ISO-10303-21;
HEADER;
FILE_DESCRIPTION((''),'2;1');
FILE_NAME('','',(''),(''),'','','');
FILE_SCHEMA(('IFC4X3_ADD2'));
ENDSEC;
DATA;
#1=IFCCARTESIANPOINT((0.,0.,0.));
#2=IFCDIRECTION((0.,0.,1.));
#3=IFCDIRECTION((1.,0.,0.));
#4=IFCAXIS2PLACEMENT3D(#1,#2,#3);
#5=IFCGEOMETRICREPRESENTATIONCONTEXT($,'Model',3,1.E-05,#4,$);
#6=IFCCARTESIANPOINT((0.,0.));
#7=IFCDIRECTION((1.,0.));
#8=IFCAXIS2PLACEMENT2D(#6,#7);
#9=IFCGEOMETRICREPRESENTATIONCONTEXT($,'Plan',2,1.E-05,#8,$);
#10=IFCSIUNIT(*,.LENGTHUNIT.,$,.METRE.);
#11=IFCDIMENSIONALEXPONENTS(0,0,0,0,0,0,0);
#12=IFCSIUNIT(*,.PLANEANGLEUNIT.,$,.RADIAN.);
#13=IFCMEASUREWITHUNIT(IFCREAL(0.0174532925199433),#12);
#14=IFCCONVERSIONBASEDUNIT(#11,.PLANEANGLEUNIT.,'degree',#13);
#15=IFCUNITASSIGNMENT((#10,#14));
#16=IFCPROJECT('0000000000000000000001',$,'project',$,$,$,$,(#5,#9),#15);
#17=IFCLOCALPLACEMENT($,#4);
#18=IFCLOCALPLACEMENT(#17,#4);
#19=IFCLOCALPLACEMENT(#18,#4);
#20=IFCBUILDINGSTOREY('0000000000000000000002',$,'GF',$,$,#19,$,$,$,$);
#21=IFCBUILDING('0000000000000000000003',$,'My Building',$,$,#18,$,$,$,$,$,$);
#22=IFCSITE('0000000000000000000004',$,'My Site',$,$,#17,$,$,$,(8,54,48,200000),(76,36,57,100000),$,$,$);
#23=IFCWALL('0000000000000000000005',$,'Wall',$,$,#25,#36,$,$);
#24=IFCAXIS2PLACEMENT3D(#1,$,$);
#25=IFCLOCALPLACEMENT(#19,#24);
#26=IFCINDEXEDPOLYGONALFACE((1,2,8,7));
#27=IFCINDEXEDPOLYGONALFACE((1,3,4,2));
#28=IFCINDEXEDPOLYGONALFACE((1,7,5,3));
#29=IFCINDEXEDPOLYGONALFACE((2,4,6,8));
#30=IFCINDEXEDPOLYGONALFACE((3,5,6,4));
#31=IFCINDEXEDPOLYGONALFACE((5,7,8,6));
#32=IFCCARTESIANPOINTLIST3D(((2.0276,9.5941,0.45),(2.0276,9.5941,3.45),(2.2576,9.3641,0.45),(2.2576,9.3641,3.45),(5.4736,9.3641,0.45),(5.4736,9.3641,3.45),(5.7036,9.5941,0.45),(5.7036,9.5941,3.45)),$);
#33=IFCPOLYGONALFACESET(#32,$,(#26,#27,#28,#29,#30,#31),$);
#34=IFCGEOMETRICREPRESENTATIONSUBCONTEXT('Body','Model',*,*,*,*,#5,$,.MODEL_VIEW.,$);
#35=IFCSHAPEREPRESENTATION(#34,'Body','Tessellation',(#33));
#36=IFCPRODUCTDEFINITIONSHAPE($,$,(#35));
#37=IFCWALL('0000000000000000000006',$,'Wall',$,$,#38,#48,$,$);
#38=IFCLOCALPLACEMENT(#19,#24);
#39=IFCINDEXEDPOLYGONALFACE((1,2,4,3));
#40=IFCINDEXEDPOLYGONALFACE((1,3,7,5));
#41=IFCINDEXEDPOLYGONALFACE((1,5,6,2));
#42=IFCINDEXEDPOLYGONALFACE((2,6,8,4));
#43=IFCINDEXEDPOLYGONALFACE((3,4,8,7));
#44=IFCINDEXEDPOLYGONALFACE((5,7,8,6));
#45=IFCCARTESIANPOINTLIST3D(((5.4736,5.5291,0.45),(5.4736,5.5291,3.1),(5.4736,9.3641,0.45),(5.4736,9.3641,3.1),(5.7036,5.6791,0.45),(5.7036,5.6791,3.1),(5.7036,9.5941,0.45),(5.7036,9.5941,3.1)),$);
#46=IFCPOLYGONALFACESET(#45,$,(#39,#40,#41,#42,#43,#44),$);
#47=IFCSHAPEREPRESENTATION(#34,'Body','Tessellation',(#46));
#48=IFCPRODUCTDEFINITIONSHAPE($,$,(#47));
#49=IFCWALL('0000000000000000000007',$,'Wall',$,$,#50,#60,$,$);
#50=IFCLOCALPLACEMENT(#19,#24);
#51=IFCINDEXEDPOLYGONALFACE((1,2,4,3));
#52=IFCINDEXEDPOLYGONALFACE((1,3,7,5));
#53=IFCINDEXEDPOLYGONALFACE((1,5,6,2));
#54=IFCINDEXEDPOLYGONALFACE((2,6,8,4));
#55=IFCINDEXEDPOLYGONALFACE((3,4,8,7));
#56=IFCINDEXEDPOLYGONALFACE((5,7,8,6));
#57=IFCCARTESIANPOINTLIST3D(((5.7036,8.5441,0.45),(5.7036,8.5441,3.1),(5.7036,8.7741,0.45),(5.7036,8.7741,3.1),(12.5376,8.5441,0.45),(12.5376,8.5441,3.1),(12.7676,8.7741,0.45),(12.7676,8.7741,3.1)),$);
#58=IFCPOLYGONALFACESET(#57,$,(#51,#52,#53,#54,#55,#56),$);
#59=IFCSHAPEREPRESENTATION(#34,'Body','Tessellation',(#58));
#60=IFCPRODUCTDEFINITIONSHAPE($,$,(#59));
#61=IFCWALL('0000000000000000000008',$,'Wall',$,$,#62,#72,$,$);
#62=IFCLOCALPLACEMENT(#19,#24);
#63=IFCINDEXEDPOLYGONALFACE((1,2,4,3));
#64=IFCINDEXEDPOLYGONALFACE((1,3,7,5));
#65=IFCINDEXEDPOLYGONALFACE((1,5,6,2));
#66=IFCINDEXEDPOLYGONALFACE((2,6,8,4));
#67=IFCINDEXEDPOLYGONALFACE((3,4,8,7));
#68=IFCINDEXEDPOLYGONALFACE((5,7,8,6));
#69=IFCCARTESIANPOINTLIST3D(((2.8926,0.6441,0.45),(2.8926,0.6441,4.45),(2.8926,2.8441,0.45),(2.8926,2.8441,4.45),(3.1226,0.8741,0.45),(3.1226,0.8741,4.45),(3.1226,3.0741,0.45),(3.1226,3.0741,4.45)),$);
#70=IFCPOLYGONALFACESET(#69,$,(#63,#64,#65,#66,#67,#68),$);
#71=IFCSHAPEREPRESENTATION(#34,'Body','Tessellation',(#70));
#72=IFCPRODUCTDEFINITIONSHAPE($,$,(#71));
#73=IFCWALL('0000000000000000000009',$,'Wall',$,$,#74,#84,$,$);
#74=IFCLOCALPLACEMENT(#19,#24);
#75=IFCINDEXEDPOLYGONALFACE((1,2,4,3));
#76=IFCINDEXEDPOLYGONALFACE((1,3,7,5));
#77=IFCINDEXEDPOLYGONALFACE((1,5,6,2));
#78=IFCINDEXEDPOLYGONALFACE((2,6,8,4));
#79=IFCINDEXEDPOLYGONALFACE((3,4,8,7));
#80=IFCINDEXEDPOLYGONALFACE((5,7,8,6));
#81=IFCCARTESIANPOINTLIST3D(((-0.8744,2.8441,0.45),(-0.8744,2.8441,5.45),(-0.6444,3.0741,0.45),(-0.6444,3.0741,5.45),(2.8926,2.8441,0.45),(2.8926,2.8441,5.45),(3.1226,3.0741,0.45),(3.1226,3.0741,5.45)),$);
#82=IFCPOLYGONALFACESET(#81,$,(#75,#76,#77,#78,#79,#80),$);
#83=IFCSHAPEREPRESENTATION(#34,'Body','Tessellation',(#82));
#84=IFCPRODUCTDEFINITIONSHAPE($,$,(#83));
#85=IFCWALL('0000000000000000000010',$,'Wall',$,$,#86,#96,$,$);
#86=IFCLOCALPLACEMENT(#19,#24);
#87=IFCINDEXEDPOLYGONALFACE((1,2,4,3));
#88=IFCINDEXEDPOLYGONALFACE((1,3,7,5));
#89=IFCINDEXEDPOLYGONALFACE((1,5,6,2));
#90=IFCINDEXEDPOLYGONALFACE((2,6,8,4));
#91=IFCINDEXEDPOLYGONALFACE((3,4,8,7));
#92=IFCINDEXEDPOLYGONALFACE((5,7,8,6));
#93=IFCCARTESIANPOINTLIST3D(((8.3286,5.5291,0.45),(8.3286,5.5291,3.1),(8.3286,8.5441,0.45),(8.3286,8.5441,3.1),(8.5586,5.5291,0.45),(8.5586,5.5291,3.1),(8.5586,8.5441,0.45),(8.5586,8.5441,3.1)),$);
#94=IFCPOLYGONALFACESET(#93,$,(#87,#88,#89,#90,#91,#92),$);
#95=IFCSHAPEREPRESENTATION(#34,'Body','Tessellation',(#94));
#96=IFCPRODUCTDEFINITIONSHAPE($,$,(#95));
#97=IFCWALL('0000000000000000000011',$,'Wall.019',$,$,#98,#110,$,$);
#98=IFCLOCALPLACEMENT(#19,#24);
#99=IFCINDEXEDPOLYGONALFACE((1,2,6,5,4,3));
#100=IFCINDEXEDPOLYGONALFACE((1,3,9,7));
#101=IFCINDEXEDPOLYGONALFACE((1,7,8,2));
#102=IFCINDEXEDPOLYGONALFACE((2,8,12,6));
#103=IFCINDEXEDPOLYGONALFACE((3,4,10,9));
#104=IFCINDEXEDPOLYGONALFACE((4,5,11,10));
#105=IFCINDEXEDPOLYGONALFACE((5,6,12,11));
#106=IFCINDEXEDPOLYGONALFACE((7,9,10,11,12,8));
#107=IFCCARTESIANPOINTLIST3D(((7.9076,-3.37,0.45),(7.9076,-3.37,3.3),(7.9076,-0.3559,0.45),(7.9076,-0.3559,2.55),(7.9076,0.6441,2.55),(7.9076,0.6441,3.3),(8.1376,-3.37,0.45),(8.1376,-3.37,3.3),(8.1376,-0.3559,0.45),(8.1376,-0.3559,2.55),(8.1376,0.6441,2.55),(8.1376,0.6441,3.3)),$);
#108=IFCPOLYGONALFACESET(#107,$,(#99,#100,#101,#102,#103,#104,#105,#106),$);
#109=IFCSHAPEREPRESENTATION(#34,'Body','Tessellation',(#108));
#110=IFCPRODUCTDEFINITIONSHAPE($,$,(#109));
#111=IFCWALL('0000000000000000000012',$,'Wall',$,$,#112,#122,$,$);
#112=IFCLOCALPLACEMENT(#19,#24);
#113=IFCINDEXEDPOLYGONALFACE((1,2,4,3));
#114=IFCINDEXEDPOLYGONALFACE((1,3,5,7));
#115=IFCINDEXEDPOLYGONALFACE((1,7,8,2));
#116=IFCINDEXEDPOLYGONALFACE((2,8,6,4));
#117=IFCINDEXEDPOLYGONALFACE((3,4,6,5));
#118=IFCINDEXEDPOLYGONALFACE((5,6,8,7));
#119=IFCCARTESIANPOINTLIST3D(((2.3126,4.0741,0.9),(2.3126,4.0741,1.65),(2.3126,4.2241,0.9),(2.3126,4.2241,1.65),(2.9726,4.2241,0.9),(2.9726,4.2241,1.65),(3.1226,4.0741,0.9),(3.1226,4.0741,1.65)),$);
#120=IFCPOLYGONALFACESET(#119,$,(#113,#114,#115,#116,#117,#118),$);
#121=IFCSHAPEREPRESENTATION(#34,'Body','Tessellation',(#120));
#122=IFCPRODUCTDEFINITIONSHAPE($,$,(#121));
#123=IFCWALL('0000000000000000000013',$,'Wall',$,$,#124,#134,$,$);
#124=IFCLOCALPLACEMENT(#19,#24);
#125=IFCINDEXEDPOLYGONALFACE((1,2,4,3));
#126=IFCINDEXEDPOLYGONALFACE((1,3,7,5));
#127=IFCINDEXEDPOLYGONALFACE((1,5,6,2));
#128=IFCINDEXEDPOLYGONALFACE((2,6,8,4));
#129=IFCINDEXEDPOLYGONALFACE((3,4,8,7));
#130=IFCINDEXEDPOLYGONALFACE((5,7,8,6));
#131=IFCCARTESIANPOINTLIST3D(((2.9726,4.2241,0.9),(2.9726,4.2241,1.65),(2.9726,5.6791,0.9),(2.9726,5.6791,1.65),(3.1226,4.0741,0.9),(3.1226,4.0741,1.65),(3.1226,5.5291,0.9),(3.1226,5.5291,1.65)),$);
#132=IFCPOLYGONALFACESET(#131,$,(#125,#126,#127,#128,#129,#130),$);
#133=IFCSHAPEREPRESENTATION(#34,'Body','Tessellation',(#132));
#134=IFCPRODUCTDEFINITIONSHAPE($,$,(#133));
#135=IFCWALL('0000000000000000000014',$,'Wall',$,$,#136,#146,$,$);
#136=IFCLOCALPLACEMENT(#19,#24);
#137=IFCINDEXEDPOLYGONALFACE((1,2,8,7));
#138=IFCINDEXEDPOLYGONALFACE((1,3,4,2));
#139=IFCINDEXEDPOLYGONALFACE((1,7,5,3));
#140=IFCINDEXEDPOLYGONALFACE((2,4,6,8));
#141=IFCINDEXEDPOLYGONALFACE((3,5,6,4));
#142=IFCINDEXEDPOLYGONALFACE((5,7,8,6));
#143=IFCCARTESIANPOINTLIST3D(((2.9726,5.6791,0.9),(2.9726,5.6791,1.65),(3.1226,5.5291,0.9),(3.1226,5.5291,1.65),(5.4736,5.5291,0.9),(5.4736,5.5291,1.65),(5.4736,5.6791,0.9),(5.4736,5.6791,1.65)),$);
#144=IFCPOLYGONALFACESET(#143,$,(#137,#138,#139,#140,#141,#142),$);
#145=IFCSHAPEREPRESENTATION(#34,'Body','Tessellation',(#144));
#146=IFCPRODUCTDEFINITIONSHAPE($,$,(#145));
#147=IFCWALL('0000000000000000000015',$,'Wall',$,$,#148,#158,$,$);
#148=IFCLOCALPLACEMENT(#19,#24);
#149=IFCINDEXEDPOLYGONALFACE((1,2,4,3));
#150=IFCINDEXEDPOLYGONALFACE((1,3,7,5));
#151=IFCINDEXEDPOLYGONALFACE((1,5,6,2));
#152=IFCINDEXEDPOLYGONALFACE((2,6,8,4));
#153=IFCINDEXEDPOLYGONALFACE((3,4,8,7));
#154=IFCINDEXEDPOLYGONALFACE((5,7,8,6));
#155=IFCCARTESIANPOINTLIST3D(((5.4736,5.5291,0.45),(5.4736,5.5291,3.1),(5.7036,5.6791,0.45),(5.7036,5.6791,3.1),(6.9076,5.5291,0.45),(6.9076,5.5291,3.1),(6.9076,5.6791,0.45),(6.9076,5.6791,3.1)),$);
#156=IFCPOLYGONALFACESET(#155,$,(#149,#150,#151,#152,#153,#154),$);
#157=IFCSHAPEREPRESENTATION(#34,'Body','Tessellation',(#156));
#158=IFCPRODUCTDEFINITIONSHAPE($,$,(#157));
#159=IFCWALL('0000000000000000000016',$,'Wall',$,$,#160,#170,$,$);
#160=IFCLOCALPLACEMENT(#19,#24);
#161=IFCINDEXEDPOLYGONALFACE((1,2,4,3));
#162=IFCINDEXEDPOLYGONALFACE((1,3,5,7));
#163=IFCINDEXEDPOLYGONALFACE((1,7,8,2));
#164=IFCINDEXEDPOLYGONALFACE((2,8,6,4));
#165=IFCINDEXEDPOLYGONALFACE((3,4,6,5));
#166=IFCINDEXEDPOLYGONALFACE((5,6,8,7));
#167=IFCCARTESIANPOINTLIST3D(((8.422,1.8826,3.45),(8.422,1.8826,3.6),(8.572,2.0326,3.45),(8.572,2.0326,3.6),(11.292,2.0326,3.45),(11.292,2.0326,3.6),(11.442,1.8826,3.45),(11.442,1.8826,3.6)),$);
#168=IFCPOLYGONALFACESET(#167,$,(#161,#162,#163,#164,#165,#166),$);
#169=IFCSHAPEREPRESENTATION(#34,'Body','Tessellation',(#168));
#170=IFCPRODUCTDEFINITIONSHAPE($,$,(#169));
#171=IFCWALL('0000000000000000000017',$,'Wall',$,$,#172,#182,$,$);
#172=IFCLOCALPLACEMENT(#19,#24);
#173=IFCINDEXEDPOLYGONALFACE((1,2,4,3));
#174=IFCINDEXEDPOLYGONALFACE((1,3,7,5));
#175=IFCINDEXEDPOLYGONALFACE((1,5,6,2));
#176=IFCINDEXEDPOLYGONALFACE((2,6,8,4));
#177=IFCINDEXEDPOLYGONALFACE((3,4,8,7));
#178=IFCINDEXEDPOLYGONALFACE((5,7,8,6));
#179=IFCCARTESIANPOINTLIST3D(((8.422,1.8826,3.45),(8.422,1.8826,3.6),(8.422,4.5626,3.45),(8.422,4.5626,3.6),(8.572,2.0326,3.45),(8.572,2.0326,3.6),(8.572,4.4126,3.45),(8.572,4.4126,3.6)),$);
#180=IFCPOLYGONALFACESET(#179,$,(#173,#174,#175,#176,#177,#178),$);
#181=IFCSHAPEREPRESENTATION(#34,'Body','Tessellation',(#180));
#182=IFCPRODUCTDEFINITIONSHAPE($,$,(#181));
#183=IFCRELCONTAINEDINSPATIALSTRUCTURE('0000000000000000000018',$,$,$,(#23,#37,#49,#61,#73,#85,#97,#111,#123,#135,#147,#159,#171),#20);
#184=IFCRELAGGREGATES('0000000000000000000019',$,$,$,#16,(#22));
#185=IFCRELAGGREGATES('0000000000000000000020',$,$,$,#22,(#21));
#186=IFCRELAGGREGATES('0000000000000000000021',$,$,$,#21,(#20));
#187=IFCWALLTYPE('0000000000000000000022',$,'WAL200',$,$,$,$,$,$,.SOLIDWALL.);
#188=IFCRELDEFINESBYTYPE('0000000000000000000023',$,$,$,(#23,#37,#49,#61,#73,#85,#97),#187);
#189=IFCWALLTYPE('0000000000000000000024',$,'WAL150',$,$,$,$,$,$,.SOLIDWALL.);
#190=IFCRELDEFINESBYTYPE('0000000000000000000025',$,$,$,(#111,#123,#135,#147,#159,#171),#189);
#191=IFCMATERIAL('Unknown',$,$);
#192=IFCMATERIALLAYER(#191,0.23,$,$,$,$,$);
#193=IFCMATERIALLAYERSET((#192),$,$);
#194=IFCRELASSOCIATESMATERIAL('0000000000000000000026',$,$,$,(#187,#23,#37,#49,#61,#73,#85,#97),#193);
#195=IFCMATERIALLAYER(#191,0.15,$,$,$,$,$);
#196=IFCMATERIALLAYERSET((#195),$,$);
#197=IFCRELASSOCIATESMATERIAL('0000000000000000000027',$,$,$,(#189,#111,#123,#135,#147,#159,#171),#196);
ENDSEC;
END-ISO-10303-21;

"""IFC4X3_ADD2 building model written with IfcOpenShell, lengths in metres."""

from ifc_helpers import new_model, entity, si_unit, converted_unit, frame, origin_with_axes, origin_2d_with_axis, place, context, subcontext, project, spatial, line, indexed_curve, outline, extrude, material, layer, layer_set, layer_usage, type_object, element, save


model = new_model("IFC4X3_ADD2")

# Units and contexts
model_context = context("Model", 3, precision=1e-05, world=origin_with_axes())
plan_context = context("Plan", 2, precision=1e-05, world=origin_2d_with_axis())
body_context = subcontext(model_context, "Body", "Model", "MODEL_VIEW")
ifc_project = project(units=[si_unit("LENGTHUNIT", "METRE"), converted_unit("PLANEANGLEUNIT", "degree", entity("IfcReal", 0.0174532925199433), si_unit("PLANEANGLEUNIT", "RADIAN"), dimensions=[0, 0, 0, 0, 0, 0, 0])], contexts=[model_context, plan_context])

# Site, building, storey
site_placement = place(None, origin_with_axes())
site = spatial("IfcSite", under=ifc_project, at=site_placement, Name="My Site", RefLatitude=(8, 54, 48, 200000), RefLongitude=(76, 36, 57, 100000))
building_placement = place(site_placement, origin_with_axes())
building = spatial("IfcBuilding", under=site, at=building_placement, Name="My Building")
storey_placement = place(building_placement, origin_with_axes())
storey = spatial("IfcBuildingStorey", under=building, at=storey_placement, Name="GF")

# Walls
ifc_material_1 = material(Name="Unknown")
ifc_layer_1 = layer(ifc_material_1, 0.23)
ifc_layer_set_1 = layer_set([ifc_layer_1])
ifc_layer_usage_1 = layer_usage(ifc_layer_set_1, "AXIS2", "POSITIVE", 0.0)
wall_type_1 = type_object("IfcWallType", Name="WAL200", PredefinedType="SOLIDWALL", material=ifc_layer_set_1)
wall_1_placement = place(storey_placement, frame((2.2576, 9.3641, 0.45), z_axis=(0.0, 0.0, 1.0), x_axis=(1.0, 0.0, 0.0)))
element("IfcWall", 1, at=wall_1_placement, inside=storey, type_object=wall_type_1, material=ifc_layer_usage_1, Name="Wall", context=body_context, shape_type="SweptSolid", body=[
    extrude(outline(indexed_curve([(0.0, 0.0), (-0.23, 0.23), (3.446, 0.23), (3.216, 0.0)], segments=[line(1, 2, 3, 4, 1)])), origin_with_axes(), (0.0, 0.0, 1.0), 3.0),
])
ifc_layer_usage_2 = layer_usage(ifc_layer_set_1, "AXIS2", "POSITIVE", 0.0)
wall_2_placement = place(storey_placement, frame((5.4736, 9.3641, 0.45), z_axis=(0.0, 0.0, 1.0), x_axis=(0.0, -1.0, 0.0)))
element("IfcWall", 2, at=wall_2_placement, inside=storey, type_object=wall_type_1, material=ifc_layer_usage_2, Name="Wall", context=body_context, shape_type="SweptSolid", body=[
    extrude(outline(indexed_curve([(0.0, 0.0), (-0.23, 0.23), (3.685, 0.23), (3.835, 0.0)], segments=[line(1, 2, 3, 4, 1)])), origin_with_axes(), (0.0, 0.0, 1.0), 2.65),
])
ifc_layer_usage_3 = layer_usage(ifc_layer_set_1, "AXIS2", "POSITIVE", 0.0)
wall_3_placement = place(storey_placement, frame((5.7036, 8.5441, 0.45), z_axis=(0.0, 0.0, 1.0), x_axis=(1.0, 0.0, 0.0)))
element("IfcWall", 3, at=wall_3_placement, inside=storey, type_object=wall_type_1, material=ifc_layer_usage_3, Name="Wall", context=body_context, shape_type="SweptSolid", body=[
    extrude(outline(indexed_curve([(0.0, 0.0), (0.0, 0.23), (7.064, 0.23), (6.834, 0.0)], segments=[line(1, 2, 3, 4, 1)])), origin_with_axes(), (0.0, 0.0, 1.0), 2.65),
])
ifc_layer_usage_4 = layer_usage(ifc_layer_set_1, "AXIS2", "POSITIVE", 0.0)
wall_4_placement = place(storey_placement, frame((3.1226, 0.8741, 0.45), z_axis=(0.0, 0.0, 1.0), x_axis=(0.0, 1.0, 0.0)))
element("IfcWall", 4, at=wall_4_placement, inside=storey, type_object=wall_type_1, material=ifc_layer_usage_4, Name="Wall", context=body_context, shape_type="SweptSolid", body=[
    extrude(outline(indexed_curve([(0.0, 0.0), (-0.23, 0.23), (1.97, 0.23), (2.2, 0.0)], segments=[line(1, 2, 3, 4, 1)])), origin_with_axes(), (0.0, 0.0, 1.0), 4.0),
])
ifc_layer_usage_5 = layer_usage(ifc_layer_set_1, "AXIS2", "NEGATIVE", 0.0)
wall_5_placement = place(storey_placement, frame((3.1226, 2.8441, 0.45), z_axis=(0.0, 0.0, 1.0), x_axis=(-1.0, 0.0, 0.0)))
element("IfcWall", 5, at=wall_5_placement, inside=storey, type_object=wall_type_1, material=ifc_layer_usage_5, Name="Wall", context=body_context, shape_type="SweptSolid", body=[
    extrude(outline(indexed_curve([(0.0, -0.23), (0.23, 0.0), (3.997, 0.0), (3.767, -0.23)], segments=[line(1, 2, 3, 4, 1)])), origin_with_axes(), (0.0, 0.0, 1.0), 5.0),
])
ifc_layer_usage_6 = layer_usage(ifc_layer_set_1, "AXIS2", "POSITIVE", 0.0)
wall_6_placement = place(storey_placement, frame((8.3286, 8.5441, 0.45), z_axis=(0.0, 0.0, 1.0), x_axis=(0.0, -1.0, 0.0)))
element("IfcWall", 6, at=wall_6_placement, inside=storey, type_object=wall_type_1, material=ifc_layer_usage_6, Name="Wall", context=body_context, shape_type="SweptSolid", body=[
    extrude(outline(indexed_curve([(0.0, 0.0), (0.0, 0.23), (3.015, 0.23), (3.015, 0.0)], segments=[line(1, 2, 3, 4, 1)])), origin_with_axes(), (0.0, 0.0, 1.0), 2.65),
])

# Wall, opening
ifc_layer_usage_7 = layer_usage(ifc_layer_set_1, "AXIS2", "POSITIVE", 0.0)
wall_7_placement = place(storey_placement, frame((7.9076, 0.6441, 0.45), z_axis=(0.0, 0.0, 1.0), x_axis=(0.0, -1.0, 0.0)))
wall_7 = element("IfcWall", 7, at=wall_7_placement, inside=storey, type_object=wall_type_1, material=ifc_layer_usage_7, Name="Wall.019", context=body_context, shape_type="SweptSolid", body=[
    extrude(outline(indexed_curve([(0.0, 0.0), (0.0, 0.23), (4.0141, 0.23), (4.0141, 0.0)], segments=[line(1, 2, 3, 4, 1)])), origin_with_axes(), (0.0, 0.0, 1.0), 2.85),
])
opening_placement = place(wall_7_placement, frame((0.0, -0.1189, 0.5), z_axis=(0.0, 0.0, 1.0), x_axis=(0.0, 1.0, 0.0)))
element("IfcOpeningElement", 8, at=opening_placement, cuts=wall_7, PredefinedType="OPENING", context=body_context, shape_type="SweptSolid", body=[
    extrude(outline(indexed_curve([(0.0, 0.5), (1.0, 0.5), (1.0, -1.6), (0.0, -1.6), (0.0, 0.5)])), frame((0.0, 0.0, 0.0), z_axis=(1.0, 0.0, 0.0), x_axis=(0.0, -1.0, 0.0)), (0.0, 0.0, 1.0), 0.5),
])

# Walls
ifc_layer_2 = layer(ifc_material_1, 0.15)
ifc_layer_set_2 = layer_set([ifc_layer_2])
ifc_layer_usage_8 = layer_usage(ifc_layer_set_2, "AXIS2", "POSITIVE", 0.0)
wall_type_2 = type_object("IfcWallType", Name="WAL150", PredefinedType="SOLIDWALL", material=ifc_layer_set_2)
wall_8_placement = place(storey_placement, frame((2.3126, 4.0741, 0.9), z_axis=(0.0, 0.0, 1.0), x_axis=(1.0, 0.0, 0.0)))
element("IfcWall", 9, at=wall_8_placement, inside=storey, type_object=wall_type_2, material=ifc_layer_usage_8, Name="Wall", context=body_context, shape_type="SweptSolid", body=[
    extrude(outline(indexed_curve([(0.0, 0.0), (0.0, 0.15), (0.66, 0.15), (0.81, 0.0)], segments=[line(1, 2, 3, 4, 1)])), origin_with_axes(), (0.0, 0.0, 1.0), 0.75),
])
ifc_layer_usage_9 = layer_usage(ifc_layer_set_2, "AXIS2", "POSITIVE", 0.0)
wall_9_placement = place(storey_placement, frame((3.1226, 4.0741, 0.9), z_axis=(0.0, 0.0, 1.0), x_axis=(0.0, 1.0, 0.0)))
element("IfcWall", 10, at=wall_9_placement, inside=storey, type_object=wall_type_2, material=ifc_layer_usage_9, Name="Wall", context=body_context, shape_type="SweptSolid", body=[
    extrude(outline(indexed_curve([(0.0, 0.0), (0.15, 0.15), (1.605, 0.15), (1.455, 0.0)], segments=[line(1, 2, 3, 4, 1)])), origin_with_axes(), (0.0, 0.0, 1.0), 0.75),
])
ifc_layer_usage_10 = layer_usage(ifc_layer_set_2, "AXIS2", "POSITIVE", 0.0)
wall_10_placement = place(storey_placement, frame((3.1226, 5.5291, 0.9), z_axis=(0.0, 0.0, 1.0), x_axis=(1.0, 0.0, 0.0)))
element("IfcWall", 11, at=wall_10_placement, inside=storey, type_object=wall_type_2, material=ifc_layer_usage_10, Name="Wall", context=body_context, shape_type="SweptSolid", body=[
    extrude(outline(indexed_curve([(0.0, 0.0), (-0.15, 0.15), (2.351, 0.15), (2.351, 0.0)], segments=[line(1, 2, 3, 4, 1)])), origin_with_axes(), (0.0, 0.0, 1.0), 0.75),
])
ifc_layer_usage_11 = layer_usage(ifc_layer_set_2, "AXIS2", "POSITIVE", 0.0)
wall_11_placement = place(storey_placement, frame((5.4736, 5.5291, 0.45), z_axis=(0.0, 0.0, 1.0), x_axis=(1.0, 0.0, 0.0)))
element("IfcWall", 12, at=wall_11_placement, inside=storey, type_object=wall_type_2, material=ifc_layer_usage_11, Name="Wall", context=body_context, shape_type="SweptSolid", body=[
    extrude(outline(indexed_curve([(0.0, 0.0), (0.23, 0.15), (1.434, 0.15), (1.434, 0.0)], segments=[line(1, 2, 3, 4, 1)])), origin_with_axes(), (0.0, 0.0, 1.0), 2.65),
])
ifc_layer_usage_12 = layer_usage(ifc_layer_set_2, "AXIS2", "POSITIVE", 0.0)
wall_12_placement = place(storey_placement, frame((8.422, 1.8826, 3.45), z_axis=(0.0, 0.0, 1.0), x_axis=(1.0, 0.0, 0.0)))
element("IfcWall", 13, at=wall_12_placement, inside=storey, type_object=wall_type_2, material=ifc_layer_usage_12, Name="Wall", context=body_context, shape_type="SweptSolid", body=[
    extrude(outline(indexed_curve([(0.0, 0.0), (0.15, 0.15), (2.87, 0.15), (3.02, 0.0)], segments=[line(1, 2, 3, 4, 1)])), origin_with_axes(), (0.0, 0.0, 1.0), 0.15),
])
ifc_layer_usage_13 = layer_usage(ifc_layer_set_2, "AXIS2", "POSITIVE", 0.0)
wall_13_placement = place(storey_placement, frame((8.422, 4.4126, 3.45), z_axis=(0.0, 0.0, 1.0), x_axis=(0.0, -1.0, 0.0)))
element("IfcWall", 14, at=wall_13_placement, inside=storey, type_object=wall_type_2, material=ifc_layer_usage_13, Name="Wall", context=body_context, shape_type="SweptSolid", body=[
    extrude(outline(indexed_curve([(-0.15, 0.0), (0.0, 0.15), (2.38, 0.15), (2.53, 0.0)], segments=[line(1, 2, 3, 4, 1)])), origin_with_axes(), (0.0, 0.0, 1.0), 0.15),
])

save(model, "model.ifc")
